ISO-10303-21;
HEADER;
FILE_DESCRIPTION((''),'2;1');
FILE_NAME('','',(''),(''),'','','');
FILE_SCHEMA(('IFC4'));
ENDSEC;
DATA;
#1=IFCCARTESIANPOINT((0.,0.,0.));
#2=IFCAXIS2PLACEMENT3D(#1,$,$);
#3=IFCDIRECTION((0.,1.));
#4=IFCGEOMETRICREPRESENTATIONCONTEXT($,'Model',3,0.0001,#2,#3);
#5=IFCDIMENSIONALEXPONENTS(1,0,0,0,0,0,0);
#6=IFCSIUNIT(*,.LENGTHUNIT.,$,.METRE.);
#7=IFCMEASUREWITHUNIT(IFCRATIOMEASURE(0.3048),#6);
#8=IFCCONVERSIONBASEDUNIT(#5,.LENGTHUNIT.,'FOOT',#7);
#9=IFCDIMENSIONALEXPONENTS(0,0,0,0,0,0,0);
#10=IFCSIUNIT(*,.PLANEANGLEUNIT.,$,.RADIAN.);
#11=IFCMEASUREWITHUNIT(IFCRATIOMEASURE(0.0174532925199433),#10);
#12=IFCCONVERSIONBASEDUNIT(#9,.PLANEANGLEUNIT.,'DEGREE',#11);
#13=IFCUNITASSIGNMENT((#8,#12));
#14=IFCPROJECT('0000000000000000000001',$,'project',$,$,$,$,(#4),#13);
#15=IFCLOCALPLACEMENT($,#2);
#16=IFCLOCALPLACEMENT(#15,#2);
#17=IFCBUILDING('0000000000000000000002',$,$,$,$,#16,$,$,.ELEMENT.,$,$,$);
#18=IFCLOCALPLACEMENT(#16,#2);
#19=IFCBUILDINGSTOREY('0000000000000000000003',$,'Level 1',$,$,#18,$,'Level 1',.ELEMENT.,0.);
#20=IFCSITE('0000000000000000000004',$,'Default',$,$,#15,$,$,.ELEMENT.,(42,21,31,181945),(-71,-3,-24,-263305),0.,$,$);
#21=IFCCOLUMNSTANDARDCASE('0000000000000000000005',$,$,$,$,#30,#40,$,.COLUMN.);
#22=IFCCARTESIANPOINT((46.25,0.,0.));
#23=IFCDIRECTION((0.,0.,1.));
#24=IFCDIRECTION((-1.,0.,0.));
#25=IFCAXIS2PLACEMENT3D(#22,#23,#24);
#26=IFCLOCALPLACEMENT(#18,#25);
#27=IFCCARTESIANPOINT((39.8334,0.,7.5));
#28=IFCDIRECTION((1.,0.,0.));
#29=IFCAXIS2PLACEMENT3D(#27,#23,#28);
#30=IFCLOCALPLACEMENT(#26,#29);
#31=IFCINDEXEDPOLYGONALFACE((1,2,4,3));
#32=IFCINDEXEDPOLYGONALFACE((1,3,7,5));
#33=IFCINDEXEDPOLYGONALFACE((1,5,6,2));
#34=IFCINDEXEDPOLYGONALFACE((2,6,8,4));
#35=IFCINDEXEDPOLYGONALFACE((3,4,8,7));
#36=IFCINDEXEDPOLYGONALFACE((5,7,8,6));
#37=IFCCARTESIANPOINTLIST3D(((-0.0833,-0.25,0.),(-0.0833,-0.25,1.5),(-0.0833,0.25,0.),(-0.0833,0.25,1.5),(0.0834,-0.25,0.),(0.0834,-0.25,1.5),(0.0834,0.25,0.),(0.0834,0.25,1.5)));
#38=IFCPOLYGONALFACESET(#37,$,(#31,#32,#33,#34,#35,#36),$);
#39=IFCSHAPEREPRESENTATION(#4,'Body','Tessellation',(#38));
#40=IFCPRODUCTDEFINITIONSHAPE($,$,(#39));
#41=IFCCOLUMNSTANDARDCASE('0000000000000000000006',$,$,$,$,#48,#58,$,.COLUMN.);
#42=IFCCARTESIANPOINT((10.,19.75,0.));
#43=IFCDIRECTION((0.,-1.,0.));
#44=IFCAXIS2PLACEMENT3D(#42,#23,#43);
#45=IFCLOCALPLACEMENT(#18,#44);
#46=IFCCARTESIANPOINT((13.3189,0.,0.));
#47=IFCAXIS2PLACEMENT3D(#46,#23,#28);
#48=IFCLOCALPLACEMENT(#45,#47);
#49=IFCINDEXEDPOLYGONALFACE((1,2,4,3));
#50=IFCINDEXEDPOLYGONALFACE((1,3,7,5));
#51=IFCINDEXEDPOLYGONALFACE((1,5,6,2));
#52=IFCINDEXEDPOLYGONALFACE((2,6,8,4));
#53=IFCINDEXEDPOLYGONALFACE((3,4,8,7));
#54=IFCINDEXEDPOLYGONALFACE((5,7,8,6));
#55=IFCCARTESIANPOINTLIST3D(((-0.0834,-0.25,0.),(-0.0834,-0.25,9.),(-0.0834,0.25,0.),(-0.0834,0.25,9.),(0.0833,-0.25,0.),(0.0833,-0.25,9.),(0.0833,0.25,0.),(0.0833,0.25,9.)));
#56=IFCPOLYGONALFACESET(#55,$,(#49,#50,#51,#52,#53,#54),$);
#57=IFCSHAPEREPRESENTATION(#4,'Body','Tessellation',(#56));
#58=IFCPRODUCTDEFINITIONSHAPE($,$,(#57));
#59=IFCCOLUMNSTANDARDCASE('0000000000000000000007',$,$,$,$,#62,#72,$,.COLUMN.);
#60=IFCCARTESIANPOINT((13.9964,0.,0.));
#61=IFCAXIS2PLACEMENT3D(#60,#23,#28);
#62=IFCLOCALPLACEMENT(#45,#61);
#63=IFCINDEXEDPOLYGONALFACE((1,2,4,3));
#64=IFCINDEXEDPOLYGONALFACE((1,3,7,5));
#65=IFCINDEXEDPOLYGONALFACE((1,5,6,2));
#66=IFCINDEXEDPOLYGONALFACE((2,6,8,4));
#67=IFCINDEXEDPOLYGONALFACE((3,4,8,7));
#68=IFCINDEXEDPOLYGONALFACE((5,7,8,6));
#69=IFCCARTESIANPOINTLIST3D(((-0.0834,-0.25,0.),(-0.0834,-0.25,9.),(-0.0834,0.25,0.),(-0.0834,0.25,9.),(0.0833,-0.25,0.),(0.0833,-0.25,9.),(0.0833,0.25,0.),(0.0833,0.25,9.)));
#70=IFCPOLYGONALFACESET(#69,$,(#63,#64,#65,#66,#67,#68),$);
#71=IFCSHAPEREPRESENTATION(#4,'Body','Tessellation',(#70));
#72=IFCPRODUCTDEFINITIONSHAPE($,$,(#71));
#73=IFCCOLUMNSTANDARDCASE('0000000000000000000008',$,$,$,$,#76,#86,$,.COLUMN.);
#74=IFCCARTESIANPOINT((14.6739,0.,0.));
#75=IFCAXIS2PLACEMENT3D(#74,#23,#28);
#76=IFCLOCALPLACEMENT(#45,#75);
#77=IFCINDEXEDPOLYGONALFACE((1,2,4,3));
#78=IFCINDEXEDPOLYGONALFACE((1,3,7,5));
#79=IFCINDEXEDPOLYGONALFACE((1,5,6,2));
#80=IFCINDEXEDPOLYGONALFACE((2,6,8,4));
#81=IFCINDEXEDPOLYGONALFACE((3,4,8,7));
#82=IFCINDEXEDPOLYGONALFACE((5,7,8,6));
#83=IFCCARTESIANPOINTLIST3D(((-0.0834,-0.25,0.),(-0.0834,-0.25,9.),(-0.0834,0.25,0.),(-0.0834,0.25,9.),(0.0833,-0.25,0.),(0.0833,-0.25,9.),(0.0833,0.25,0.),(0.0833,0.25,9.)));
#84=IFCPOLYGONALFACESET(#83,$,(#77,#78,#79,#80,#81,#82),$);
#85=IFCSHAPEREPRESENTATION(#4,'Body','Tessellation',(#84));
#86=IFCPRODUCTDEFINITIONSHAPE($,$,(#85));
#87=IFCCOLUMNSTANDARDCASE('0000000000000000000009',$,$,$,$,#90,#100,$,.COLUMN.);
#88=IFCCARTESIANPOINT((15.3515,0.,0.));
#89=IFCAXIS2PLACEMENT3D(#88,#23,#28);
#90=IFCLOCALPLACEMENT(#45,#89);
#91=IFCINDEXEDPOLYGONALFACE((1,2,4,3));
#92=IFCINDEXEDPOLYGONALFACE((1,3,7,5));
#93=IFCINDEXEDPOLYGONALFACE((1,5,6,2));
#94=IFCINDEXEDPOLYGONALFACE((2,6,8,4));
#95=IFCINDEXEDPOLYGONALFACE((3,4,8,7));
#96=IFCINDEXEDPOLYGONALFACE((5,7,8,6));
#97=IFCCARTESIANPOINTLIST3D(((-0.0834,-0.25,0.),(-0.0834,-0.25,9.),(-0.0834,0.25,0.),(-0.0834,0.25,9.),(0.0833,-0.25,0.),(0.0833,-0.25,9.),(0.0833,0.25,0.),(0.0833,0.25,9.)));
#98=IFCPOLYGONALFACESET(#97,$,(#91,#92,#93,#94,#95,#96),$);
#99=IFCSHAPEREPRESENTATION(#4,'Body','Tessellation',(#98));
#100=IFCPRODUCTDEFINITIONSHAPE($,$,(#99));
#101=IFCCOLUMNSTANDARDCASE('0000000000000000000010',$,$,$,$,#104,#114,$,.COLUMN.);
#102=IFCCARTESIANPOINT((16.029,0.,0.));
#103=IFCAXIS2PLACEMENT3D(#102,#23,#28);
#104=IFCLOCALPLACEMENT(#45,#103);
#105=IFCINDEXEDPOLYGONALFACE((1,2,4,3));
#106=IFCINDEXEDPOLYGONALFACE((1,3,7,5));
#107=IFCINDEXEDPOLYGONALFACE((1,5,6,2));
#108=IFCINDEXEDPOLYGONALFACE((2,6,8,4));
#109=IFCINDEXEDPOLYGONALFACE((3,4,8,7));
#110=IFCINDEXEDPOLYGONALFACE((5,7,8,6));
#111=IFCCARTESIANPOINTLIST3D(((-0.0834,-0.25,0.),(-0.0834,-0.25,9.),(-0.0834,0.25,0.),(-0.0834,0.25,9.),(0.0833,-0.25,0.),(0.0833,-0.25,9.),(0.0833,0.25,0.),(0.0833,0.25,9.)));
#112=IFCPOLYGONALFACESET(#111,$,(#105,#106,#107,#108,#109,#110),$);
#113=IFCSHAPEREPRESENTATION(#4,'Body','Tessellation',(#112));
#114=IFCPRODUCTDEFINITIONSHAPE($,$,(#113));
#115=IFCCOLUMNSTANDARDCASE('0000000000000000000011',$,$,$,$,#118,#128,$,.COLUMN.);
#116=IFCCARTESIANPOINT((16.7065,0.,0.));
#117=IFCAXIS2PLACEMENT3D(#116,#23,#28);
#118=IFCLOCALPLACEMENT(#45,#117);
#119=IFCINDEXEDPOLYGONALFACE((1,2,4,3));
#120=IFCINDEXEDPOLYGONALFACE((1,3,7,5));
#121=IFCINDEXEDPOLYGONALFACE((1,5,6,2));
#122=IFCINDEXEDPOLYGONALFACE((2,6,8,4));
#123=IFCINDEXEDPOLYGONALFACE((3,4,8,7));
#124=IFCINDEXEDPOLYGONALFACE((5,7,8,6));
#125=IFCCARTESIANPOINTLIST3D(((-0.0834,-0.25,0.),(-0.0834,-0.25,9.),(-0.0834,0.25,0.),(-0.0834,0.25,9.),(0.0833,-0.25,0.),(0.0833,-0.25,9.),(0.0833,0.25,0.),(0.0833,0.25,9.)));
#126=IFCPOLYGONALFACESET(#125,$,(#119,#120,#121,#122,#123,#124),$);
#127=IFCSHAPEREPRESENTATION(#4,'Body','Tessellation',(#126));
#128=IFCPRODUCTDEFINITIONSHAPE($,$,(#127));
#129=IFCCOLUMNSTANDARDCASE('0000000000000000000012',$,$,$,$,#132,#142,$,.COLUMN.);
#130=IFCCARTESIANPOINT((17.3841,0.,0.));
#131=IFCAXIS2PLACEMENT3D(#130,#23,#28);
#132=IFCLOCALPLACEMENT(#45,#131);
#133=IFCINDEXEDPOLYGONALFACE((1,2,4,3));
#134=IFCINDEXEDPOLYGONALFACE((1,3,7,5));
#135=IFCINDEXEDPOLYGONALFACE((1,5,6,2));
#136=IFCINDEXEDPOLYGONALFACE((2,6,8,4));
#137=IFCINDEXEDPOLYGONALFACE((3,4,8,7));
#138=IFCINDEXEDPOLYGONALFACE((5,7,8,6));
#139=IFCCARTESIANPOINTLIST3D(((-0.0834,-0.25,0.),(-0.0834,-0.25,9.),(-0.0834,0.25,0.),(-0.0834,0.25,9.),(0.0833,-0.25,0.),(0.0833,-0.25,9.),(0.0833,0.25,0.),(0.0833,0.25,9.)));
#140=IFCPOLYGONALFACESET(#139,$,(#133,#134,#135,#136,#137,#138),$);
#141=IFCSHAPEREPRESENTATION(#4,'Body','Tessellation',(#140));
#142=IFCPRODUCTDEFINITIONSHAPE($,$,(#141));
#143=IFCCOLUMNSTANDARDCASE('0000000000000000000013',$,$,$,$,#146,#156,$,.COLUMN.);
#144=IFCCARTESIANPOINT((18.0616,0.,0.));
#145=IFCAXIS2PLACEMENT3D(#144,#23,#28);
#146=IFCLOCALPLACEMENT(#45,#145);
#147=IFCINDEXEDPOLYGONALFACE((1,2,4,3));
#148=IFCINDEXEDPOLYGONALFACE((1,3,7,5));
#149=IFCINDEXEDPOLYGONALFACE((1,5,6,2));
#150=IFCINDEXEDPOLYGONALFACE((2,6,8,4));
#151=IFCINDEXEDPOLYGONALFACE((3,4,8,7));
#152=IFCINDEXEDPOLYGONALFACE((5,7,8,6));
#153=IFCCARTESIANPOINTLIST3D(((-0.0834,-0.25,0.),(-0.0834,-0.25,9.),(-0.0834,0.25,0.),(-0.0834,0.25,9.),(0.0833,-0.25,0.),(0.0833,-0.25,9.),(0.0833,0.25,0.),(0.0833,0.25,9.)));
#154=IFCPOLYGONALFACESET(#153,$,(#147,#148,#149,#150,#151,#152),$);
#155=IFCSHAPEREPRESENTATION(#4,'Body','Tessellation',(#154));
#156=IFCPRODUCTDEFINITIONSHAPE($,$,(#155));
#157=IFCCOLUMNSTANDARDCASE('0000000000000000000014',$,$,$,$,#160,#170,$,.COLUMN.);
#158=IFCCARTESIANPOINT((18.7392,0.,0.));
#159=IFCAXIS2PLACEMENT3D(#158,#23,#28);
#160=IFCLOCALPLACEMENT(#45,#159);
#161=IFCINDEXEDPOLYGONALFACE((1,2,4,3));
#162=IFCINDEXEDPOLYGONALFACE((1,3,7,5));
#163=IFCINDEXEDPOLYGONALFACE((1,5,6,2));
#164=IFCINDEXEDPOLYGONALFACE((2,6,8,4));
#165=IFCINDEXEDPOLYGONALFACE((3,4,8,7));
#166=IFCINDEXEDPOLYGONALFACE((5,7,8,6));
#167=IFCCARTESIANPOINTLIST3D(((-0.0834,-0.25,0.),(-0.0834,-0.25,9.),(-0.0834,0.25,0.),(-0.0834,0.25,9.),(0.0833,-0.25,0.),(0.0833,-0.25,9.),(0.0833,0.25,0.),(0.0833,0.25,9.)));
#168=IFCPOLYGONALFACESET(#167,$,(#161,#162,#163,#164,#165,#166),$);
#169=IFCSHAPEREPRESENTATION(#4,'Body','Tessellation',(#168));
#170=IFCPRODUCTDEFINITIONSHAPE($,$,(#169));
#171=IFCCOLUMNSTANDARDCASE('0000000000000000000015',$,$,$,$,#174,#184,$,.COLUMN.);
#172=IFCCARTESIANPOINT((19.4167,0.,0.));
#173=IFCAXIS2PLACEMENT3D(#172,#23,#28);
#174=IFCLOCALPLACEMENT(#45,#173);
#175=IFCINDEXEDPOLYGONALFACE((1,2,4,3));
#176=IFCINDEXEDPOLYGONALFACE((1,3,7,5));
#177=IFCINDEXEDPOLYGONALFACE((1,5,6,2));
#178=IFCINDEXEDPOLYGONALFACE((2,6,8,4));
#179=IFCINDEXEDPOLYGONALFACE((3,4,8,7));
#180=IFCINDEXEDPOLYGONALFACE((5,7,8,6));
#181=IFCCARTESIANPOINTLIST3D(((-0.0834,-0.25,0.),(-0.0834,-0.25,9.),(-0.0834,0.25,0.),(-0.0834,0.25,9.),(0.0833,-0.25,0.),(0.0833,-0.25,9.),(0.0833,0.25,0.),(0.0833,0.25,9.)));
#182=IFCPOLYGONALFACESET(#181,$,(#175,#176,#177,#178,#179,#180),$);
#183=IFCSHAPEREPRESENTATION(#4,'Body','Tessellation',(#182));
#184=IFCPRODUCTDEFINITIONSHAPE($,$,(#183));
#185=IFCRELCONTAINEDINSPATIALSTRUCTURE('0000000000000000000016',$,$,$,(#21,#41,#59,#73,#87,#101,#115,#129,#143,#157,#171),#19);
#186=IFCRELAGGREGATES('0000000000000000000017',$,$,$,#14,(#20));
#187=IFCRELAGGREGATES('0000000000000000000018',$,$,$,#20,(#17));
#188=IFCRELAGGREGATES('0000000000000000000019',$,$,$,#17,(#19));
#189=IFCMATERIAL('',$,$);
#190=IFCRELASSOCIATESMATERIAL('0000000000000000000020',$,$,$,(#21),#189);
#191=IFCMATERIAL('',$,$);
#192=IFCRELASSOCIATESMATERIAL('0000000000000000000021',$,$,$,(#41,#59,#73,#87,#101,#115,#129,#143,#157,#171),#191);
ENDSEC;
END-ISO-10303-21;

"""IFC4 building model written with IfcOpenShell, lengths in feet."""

from ifc_helpers import new_model, entity, si_unit, converted_unit, direction, frame, origin, place, context, project, spatial, rectangle, extrude, material, element, save


model = new_model("IFC4")

# Units and contexts
model_context = context("Model", 3, precision=0.0001, world=origin(), true_north=direction((0.0, 1.0)))
ifc_project = project(units=[converted_unit("LENGTHUNIT", "FOOT", entity("IfcRatioMeasure", 0.3048), si_unit("LENGTHUNIT", "METRE"), dimensions=[1, 0, 0, 0, 0, 0, 0]), converted_unit("PLANEANGLEUNIT", "DEGREE", entity("IfcRatioMeasure", 0.0174532925199433), si_unit("PLANEANGLEUNIT", "RADIAN"), dimensions=[0, 0, 0, 0, 0, 0, 0])], contexts=[model_context])

# Site, building, storey
site_placement = place(None, origin())
site = spatial("IfcSite", under=ifc_project, at=site_placement, Name="Default", CompositionType="ELEMENT", RefLatitude=(42, 21, 31, 181945), RefLongitude=(-71, -3, -24, -263305), RefElevation=0.0)
building_placement = place(site_placement, origin())
building = spatial("IfcBuilding", under=site, at=building_placement, CompositionType="ELEMENT")
storey_placement = place(building_placement, origin())
storey = spatial("IfcBuildingStorey", under=building, at=storey_placement, Name="Level 1", LongName="Level 1", CompositionType="ELEMENT", Elevation=0.0)

# Columns
placement_1 = place(storey_placement, frame((46.25, 0.0, 0.0), z_axis=(0.0, 0.0, 1.0), x_axis=(-1.0, 0.0, 0.0)))
ifc_material_1 = material(Name="")
for number, where, z_axis, x_axis in (
    (1, (39.8334, 0.0, 7.5), (0.0, 0.0, 1.0), (1.0, 0.0, 0.0)),
):
    element("IfcColumnStandardCase", number, at=place(placement_1, frame(where, z_axis=z_axis, x_axis=x_axis)), inside=storey, material=ifc_material_1, PredefinedType="COLUMN", context=model_context, shape_type="SweptSolid", body=[
        extrude(rectangle(XDim=0.1667, YDim=0.5), origin(), (0.0, 0.0, 1.0), 1.5),
    ])
ifc_material_2 = material(Name="")
placement_2 = place(storey_placement, frame((10.0, 19.75, 0.0), z_axis=(0.0, 0.0, 1.0), x_axis=(0.0, -1.0, 0.0)))
for number, where, z_axis, x_axis in (
    (2, (13.3189, 0.0, 0.0), (0.0, 0.0, 1.0), (1.0, 0.0, 0.0)),
    (3, (13.9964, 0.0, 0.0), (0.0, 0.0, 1.0), (1.0, 0.0, 0.0)),
    (4, (14.6739, 0.0, 0.0), (0.0, 0.0, 1.0), (1.0, 0.0, 0.0)),
    (5, (15.3515, 0.0, 0.0), (0.0, 0.0, 1.0), (1.0, 0.0, 0.0)),
    (6, (16.029, 0.0, 0.0), (0.0, 0.0, 1.0), (1.0, 0.0, 0.0)),
    (7, (16.7065, 0.0, 0.0), (0.0, 0.0, 1.0), (1.0, 0.0, 0.0)),
    (8, (17.3841, 0.0, 0.0), (0.0, 0.0, 1.0), (1.0, 0.0, 0.0)),
    (9, (18.0616, 0.0, 0.0), (0.0, 0.0, 1.0), (1.0, 0.0, 0.0)),
    (10, (18.7392, 0.0, 0.0), (0.0, 0.0, 1.0), (1.0, 0.0, 0.0)),
    (11, (19.4167, 0.0, 0.0), (0.0, 0.0, 1.0), (1.0, 0.0, 0.0)),
):
    element("IfcColumnStandardCase", number, at=place(placement_2, frame(where, z_axis=z_axis, x_axis=x_axis)), inside=storey, material=ifc_material_2, PredefinedType="COLUMN", context=model_context, shape_type="SweptSolid", body=[
        extrude(rectangle(XDim=0.1667, YDim=0.5), origin(), (0.0, 0.0, 1.0), 9.0),
    ])

save(model, "model.ifc")
